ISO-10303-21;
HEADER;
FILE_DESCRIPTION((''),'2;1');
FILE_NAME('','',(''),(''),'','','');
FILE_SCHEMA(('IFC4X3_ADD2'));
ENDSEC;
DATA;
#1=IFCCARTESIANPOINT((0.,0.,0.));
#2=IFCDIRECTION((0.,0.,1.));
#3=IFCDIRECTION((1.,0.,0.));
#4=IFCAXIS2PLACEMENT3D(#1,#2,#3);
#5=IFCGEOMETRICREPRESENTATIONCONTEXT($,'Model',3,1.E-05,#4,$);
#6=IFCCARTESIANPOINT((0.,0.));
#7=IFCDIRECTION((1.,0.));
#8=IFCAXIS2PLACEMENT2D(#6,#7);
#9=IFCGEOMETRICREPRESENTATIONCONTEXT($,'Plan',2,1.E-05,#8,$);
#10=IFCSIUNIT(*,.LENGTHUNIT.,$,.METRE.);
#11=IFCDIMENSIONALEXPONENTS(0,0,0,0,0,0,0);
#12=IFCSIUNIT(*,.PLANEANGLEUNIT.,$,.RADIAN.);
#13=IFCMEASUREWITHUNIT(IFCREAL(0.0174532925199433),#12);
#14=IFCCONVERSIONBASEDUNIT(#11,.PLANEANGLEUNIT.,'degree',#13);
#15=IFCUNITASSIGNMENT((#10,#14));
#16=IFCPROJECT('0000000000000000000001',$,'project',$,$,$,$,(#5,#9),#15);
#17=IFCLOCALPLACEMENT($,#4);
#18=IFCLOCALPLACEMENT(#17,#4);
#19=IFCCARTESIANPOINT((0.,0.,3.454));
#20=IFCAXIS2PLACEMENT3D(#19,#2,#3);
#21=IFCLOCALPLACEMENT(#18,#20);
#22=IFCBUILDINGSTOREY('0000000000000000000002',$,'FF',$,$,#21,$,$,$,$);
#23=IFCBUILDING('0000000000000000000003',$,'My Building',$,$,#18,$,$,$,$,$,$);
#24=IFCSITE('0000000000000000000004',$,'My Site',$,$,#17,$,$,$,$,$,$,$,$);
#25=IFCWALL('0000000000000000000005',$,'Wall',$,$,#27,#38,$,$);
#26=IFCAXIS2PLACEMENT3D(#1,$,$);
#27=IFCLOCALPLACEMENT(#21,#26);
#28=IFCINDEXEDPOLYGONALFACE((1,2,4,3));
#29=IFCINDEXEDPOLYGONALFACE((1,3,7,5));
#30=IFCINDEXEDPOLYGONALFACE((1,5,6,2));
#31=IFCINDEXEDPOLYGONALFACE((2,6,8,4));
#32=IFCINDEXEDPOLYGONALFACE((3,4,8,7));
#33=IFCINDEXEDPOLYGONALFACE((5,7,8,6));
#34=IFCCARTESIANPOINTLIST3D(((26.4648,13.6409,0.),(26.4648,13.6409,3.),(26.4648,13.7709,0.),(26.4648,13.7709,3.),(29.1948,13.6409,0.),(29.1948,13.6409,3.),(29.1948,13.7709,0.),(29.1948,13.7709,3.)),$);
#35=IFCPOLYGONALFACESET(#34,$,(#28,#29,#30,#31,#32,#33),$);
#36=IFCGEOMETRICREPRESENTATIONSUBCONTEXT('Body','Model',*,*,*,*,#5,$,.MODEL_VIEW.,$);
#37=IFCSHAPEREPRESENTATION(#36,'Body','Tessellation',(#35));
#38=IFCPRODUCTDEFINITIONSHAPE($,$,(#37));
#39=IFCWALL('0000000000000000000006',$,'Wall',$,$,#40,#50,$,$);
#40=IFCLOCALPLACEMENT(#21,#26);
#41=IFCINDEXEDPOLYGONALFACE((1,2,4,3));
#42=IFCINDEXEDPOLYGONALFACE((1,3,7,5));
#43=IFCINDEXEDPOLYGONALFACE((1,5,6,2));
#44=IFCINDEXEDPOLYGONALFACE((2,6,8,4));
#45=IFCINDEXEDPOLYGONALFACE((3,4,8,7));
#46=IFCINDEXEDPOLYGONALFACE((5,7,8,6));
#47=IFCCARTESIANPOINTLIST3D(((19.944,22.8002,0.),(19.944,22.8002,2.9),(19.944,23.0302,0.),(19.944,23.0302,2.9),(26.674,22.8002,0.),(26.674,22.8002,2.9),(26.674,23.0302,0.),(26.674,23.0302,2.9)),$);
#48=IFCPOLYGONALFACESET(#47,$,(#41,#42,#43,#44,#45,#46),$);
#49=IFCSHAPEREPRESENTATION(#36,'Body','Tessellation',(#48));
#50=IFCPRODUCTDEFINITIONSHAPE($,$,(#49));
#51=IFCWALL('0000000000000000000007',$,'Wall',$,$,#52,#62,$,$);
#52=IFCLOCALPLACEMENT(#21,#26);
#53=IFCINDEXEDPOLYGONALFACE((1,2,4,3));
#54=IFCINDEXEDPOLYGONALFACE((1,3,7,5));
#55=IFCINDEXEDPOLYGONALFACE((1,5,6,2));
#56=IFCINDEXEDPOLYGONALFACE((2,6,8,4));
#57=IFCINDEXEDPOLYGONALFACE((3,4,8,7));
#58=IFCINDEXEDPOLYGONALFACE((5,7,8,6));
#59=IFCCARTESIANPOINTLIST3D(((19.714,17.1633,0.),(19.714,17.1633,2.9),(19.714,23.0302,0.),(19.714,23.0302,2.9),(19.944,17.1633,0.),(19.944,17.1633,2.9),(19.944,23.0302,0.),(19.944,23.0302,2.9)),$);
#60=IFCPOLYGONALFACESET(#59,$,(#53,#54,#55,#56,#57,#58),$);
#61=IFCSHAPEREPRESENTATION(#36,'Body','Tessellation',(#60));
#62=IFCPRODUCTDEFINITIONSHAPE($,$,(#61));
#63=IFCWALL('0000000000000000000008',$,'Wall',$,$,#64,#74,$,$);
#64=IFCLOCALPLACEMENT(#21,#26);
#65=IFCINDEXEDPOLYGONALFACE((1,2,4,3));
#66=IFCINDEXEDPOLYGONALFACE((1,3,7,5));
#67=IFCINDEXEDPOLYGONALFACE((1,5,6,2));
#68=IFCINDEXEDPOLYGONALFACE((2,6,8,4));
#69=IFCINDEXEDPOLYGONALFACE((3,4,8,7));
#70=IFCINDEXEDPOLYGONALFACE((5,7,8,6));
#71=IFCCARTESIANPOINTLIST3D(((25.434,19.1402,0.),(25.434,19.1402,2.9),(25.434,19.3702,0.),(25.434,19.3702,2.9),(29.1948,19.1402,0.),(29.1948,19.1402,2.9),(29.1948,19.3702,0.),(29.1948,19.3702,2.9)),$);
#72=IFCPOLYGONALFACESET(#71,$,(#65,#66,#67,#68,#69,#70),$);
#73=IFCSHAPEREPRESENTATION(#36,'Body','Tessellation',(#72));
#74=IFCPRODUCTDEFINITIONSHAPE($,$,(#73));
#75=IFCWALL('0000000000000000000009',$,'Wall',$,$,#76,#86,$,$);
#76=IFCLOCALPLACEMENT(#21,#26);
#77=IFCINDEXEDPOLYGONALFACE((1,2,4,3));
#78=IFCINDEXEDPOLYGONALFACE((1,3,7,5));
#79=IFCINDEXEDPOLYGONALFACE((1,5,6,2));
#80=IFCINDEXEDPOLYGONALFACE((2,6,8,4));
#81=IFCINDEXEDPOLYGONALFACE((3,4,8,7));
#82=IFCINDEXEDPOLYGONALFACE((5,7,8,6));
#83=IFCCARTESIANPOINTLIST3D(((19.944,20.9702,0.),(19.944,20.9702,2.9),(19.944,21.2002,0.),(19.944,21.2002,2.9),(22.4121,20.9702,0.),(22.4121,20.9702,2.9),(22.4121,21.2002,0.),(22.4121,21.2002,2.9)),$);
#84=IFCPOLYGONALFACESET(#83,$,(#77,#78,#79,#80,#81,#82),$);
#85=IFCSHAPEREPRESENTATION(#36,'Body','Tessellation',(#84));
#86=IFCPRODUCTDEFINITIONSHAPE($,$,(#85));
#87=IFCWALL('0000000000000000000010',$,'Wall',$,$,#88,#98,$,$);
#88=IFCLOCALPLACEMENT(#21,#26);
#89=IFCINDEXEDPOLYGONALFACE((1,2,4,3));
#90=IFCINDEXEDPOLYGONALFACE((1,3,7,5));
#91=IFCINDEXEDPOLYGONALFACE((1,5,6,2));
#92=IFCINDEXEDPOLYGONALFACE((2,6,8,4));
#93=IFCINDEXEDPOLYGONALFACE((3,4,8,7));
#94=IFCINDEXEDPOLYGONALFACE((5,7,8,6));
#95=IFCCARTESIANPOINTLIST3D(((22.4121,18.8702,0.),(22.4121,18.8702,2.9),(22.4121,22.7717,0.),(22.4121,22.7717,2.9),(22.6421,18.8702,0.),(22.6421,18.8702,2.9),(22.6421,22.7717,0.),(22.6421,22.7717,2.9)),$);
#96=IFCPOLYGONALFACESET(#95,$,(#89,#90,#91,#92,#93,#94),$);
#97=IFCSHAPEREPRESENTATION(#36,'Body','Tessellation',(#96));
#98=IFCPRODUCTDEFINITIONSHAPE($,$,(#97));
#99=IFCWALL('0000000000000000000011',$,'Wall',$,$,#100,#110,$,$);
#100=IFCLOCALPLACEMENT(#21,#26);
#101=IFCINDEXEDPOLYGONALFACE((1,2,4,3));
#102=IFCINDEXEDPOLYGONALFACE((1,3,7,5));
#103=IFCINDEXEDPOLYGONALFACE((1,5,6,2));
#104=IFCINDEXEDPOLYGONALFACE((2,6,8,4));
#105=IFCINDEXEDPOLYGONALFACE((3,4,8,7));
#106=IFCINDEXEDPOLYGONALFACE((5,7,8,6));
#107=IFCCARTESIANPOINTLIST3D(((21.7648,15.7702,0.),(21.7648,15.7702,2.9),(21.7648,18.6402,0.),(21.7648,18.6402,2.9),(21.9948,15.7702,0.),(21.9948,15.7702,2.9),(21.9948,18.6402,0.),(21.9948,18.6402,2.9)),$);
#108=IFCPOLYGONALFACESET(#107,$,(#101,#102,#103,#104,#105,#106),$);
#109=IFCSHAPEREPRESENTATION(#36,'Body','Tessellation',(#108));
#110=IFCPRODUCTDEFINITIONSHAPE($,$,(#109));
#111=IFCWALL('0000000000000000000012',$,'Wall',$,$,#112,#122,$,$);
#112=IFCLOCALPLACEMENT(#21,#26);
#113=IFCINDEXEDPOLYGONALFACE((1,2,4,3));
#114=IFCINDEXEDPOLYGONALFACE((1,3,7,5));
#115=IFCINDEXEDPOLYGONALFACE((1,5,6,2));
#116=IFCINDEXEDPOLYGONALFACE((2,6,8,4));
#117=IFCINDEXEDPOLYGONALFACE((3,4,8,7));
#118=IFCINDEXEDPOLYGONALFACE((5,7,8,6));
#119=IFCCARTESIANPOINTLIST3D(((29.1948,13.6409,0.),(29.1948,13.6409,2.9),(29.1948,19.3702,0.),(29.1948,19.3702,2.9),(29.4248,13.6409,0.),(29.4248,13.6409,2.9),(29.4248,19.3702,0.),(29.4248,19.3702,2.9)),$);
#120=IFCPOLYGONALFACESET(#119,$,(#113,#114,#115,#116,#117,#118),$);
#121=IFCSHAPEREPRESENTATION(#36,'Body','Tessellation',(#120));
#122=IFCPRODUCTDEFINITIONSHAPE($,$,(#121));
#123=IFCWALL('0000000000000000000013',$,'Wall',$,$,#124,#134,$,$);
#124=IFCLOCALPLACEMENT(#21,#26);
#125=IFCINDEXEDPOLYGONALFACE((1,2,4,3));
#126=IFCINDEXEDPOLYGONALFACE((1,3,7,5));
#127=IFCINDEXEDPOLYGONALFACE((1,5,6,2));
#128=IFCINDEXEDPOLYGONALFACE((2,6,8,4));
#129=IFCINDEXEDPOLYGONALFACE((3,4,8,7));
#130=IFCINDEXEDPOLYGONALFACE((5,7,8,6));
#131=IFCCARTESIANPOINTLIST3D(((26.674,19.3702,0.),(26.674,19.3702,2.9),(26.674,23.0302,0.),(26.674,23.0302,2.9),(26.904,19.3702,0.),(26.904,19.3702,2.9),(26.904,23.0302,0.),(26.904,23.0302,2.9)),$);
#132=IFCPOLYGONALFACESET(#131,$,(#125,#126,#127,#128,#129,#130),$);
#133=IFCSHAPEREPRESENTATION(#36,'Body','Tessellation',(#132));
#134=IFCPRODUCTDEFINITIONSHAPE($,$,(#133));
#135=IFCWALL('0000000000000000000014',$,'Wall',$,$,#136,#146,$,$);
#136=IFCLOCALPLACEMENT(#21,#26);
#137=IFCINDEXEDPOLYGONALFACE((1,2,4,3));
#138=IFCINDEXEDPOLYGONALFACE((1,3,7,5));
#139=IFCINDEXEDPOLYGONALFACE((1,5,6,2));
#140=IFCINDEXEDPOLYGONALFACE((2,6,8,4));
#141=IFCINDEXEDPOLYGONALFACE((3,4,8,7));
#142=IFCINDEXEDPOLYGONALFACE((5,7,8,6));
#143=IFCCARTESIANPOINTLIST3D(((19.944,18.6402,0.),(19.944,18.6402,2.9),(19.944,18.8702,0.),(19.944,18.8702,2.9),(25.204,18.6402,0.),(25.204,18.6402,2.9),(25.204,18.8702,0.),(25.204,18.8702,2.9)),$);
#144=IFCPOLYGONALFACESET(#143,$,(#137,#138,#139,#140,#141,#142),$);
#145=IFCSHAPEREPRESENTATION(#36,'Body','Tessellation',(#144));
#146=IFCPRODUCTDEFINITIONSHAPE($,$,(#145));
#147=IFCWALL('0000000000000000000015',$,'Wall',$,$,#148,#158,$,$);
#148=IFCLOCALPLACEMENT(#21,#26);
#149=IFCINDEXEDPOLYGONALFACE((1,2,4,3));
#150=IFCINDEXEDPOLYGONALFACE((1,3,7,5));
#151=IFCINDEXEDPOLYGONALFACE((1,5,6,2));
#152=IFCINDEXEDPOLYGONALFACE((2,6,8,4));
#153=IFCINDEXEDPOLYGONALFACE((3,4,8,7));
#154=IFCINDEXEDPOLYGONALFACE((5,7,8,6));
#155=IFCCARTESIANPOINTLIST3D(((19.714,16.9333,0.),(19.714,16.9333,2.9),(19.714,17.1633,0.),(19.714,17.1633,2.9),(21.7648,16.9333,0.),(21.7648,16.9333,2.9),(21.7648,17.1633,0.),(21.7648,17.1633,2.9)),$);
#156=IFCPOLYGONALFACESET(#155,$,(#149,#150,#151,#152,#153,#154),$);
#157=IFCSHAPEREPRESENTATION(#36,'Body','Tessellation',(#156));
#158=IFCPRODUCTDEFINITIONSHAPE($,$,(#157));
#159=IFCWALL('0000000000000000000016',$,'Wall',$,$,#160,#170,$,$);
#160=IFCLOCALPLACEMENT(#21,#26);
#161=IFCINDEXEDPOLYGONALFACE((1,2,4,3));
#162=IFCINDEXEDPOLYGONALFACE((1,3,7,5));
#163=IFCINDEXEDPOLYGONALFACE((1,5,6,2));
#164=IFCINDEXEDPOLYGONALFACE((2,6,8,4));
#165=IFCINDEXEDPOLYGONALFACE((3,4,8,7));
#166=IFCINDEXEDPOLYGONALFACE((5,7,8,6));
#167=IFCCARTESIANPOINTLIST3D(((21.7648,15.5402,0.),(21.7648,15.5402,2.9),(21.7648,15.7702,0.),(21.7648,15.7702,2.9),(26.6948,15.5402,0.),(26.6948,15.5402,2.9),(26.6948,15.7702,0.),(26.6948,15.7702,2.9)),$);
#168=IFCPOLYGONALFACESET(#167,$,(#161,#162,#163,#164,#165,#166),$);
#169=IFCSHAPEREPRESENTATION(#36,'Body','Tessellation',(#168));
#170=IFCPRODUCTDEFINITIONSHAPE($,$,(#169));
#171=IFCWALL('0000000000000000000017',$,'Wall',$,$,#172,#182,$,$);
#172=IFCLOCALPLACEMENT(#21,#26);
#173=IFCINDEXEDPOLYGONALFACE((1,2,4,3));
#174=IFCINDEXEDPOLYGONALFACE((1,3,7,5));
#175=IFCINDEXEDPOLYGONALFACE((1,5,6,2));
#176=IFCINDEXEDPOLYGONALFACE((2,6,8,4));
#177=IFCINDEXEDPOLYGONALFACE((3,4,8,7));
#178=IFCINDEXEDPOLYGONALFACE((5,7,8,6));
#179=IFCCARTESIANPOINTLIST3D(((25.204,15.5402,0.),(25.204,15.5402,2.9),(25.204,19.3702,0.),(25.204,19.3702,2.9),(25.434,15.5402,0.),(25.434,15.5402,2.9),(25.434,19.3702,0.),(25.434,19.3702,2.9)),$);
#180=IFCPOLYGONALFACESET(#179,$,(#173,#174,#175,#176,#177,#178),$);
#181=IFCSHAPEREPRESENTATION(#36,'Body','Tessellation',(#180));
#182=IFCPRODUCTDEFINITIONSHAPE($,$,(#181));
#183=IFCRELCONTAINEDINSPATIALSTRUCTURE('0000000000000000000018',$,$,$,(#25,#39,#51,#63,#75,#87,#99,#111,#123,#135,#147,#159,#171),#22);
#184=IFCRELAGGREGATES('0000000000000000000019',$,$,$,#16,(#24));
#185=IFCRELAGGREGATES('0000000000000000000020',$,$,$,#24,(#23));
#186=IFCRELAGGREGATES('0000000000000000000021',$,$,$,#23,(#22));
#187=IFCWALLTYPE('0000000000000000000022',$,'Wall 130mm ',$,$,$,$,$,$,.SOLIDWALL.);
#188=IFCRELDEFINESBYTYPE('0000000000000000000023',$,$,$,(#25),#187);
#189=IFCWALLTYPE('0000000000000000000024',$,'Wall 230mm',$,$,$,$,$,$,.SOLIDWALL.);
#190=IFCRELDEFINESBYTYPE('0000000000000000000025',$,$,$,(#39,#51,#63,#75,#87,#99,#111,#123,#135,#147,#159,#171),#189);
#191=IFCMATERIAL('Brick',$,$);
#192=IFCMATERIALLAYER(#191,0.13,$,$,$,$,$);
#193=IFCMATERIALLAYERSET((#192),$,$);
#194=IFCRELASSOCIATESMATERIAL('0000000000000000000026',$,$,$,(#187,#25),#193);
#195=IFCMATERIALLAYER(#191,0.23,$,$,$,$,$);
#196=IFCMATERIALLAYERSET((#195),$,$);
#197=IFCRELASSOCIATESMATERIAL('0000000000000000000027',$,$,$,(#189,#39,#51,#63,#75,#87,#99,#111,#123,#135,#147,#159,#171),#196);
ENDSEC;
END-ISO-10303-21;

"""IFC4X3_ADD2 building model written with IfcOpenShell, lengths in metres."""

from ifc_helpers import new_model, entity, si_unit, converted_unit, frame, origin_with_axes, origin_2d_with_axis, place, context, subcontext, project, spatial, indexed_curve, outline, extrude, material, layer, layer_set, layer_usage, type_object, element, save


model = new_model("IFC4X3_ADD2")

# Units and contexts
model_context = context("Model", 3, precision=1e-05, world=origin_with_axes())
plan_context = context("Plan", 2, precision=1e-05, world=origin_2d_with_axis())
body_context = subcontext(model_context, "Body", "Model", "MODEL_VIEW")
ifc_project = project(units=[si_unit("LENGTHUNIT", "METRE"), converted_unit("PLANEANGLEUNIT", "degree", entity("IfcReal", 0.0174532925199433), si_unit("PLANEANGLEUNIT", "RADIAN"), dimensions=[0, 0, 0, 0, 0, 0, 0])], contexts=[model_context, plan_context])

# Site, building, storey
site_placement = place(None, origin_with_axes())
site = spatial("IfcSite", under=ifc_project, at=site_placement, Name="My Site")
building_placement = place(site_placement, origin_with_axes())
building = spatial("IfcBuilding", under=site, at=building_placement, Name="My Building")
storey_placement = place(building_placement, frame((0.0, 0.0, 3.454), z_axis=(0.0, 0.0, 1.0), x_axis=(1.0, 0.0, 0.0)))
storey = spatial("IfcBuildingStorey", under=building, at=storey_placement, Name="FF")

# Walls
ifc_material = material(Name="Brick")
ifc_layer_1 = layer(ifc_material, 0.13)
ifc_layer_set_1 = layer_set([ifc_layer_1])
ifc_layer_usage_1 = layer_usage(ifc_layer_set_1, "AXIS2", "POSITIVE", 0.0)
wall_type_1 = type_object("IfcWallType", Name="Wall 130mm ", PredefinedType="SOLIDWALL", material=ifc_layer_set_1)
wall_1_placement = place(storey_placement, frame((29.1948, 13.7709, 0.0), z_axis=(0.0, 0.0, 1.0), x_axis=(-1.0, 0.0, 0.0)))
element("IfcWall", 1, at=wall_1_placement, inside=storey, type_object=wall_type_1, material=ifc_layer_usage_1, Name="Wall", context=body_context, shape_type="SweptSolid", body=[
    extrude(outline(indexed_curve([(0.0, 0.0), (0.0, 0.13), (2.73, 0.13), (2.73, 0.0), (0.0, 0.0)], self_intersect=False)), origin_with_axes(), (0.0, 0.0, 1.0), 3.0),
])
ifc_layer_2 = layer(ifc_material, 0.23)
ifc_layer_set_2 = layer_set([ifc_layer_2])
ifc_layer_usage_2 = layer_usage(ifc_layer_set_2, "AXIS2", "POSITIVE", 0.0)
wall_type_2 = type_object("IfcWallType", Name="Wall 230mm", PredefinedType="SOLIDWALL", material=ifc_layer_set_2)
wall_2_placement = place(storey_placement, frame((26.674, 23.0302, 0.0), z_axis=(0.0, 0.0, 1.0), x_axis=(-1.0, 0.0, 0.0)))
element("IfcWall", 2, at=wall_2_placement, inside=storey, type_object=wall_type_2, material=ifc_layer_usage_2, Name="Wall", context=body_context, shape_type="SweptSolid", body=[
    extrude(outline(indexed_curve([(0.0, 0.0), (0.0, 0.23), (6.73, 0.23), (6.73, 0.0), (0.0, 0.0)], self_intersect=False)), origin_with_axes(), (0.0, 0.0, 1.0), 2.9),
])
ifc_layer_usage_3 = layer_usage(ifc_layer_set_2, "AXIS2", "POSITIVE", 0.0)
wall_3_placement = place(storey_placement, frame((19.944, 17.1633, 0.0), z_axis=(0.0, 0.0, 1.0), x_axis=(0.000001, 1.0, 0.0)))
element("IfcWall", 3, at=wall_3_placement, inside=storey, type_object=wall_type_2, material=ifc_layer_usage_3, Name="Wall", context=body_context, shape_type="SweptSolid", body=[
    extrude(outline(indexed_curve([(0.0, 0.0), (0.0, 0.23), (5.8669, 0.23), (5.8669, 0.0), (0.0, 0.0)], self_intersect=False)), origin_with_axes(), (0.0, 0.0, 1.0), 2.9),
])
ifc_layer_usage_4 = layer_usage(ifc_layer_set_2, "AXIS2", "POSITIVE", 0.0)
wall_4_placement = place(storey_placement, frame((29.1948, 19.3702, 0.0), z_axis=(0.0, 0.0, 1.0), x_axis=(-1.0, 0.0, 0.0)))
element("IfcWall", 4, at=wall_4_placement, inside=storey, type_object=wall_type_2, material=ifc_layer_usage_4, Name="Wall", context=body_context, shape_type="SweptSolid", body=[
    extrude(outline(indexed_curve([(0.0, 0.0), (0.0, 0.23), (3.7608, 0.23), (3.7608, 0.0), (0.0, 0.0)], self_intersect=False)), origin_with_axes(), (0.0, 0.0, 1.0), 2.9),
])
ifc_layer_usage_5 = layer_usage(ifc_layer_set_2, "AXIS2", "POSITIVE", 0.0)
wall_5_placement = place(storey_placement, frame((22.4121, 21.2002, 0.0), z_axis=(0.0, 0.0, 1.0), x_axis=(-1.0, 0.0, 0.0)))
element("IfcWall", 5, at=wall_5_placement, inside=storey, type_object=wall_type_2, material=ifc_layer_usage_5, Name="Wall", context=body_context, shape_type="SweptSolid", body=[
    extrude(outline(indexed_curve([(0.0, 0.0), (0.0, 0.23), (2.4681, 0.23), (2.4681, 0.0), (0.0, 0.0)], self_intersect=False)), origin_with_axes(), (0.0, 0.0, 1.0), 2.9),
])
ifc_layer_usage_6 = layer_usage(ifc_layer_set_2, "AXIS2", "POSITIVE", 0.0)
wall_6_placement = place(storey_placement, frame((22.6421, 18.8702, 0.0), z_axis=(0.0, 0.0, 1.0), x_axis=(0.000001, 1.0, 0.0)))
element("IfcWall", 6, at=wall_6_placement, inside=storey, type_object=wall_type_2, material=ifc_layer_usage_6, Name="Wall", context=body_context, shape_type="SweptSolid", body=[
    extrude(outline(indexed_curve([(0.0, 0.0), (0.0, 0.23), (3.9015, 0.23), (3.9015, 0.0), (0.0, 0.0)], self_intersect=False)), origin_with_axes(), (0.0, 0.0, 1.0), 2.9),
])
ifc_layer_usage_7 = layer_usage(ifc_layer_set_2, "AXIS2", "POSITIVE", 0.0)
wall_7_placement = place(storey_placement, frame((21.9948, 15.7702, 0.0), z_axis=(0.0, 0.0, 1.0), x_axis=(0.000001, 1.0, 0.0)))
element("IfcWall", 7, at=wall_7_placement, inside=storey, type_object=wall_type_2, material=ifc_layer_usage_7, Name="Wall", context=body_context, shape_type="SweptSolid", body=[
    extrude(outline(indexed_curve([(0.0, 0.0), (0.0, 0.23), (2.87, 0.23), (2.87, 0.0), (0.0, 0.0)], self_intersect=False)), origin_with_axes(), (0.0, 0.0, 1.0), 2.9),
])
ifc_layer_usage_8 = layer_usage(ifc_layer_set_2, "AXIS2", "POSITIVE", 0.0)
wall_8_placement = place(storey_placement, frame((29.4248, 13.6409, 0.0), z_axis=(0.0, 0.0, 1.0), x_axis=(0.000001, 1.0, 0.0)))
element("IfcWall", 8, at=wall_8_placement, inside=storey, type_object=wall_type_2, material=ifc_layer_usage_8, Name="Wall", context=body_context, shape_type="SweptSolid", body=[
    extrude(outline(indexed_curve([(0.0, 0.0), (0.0, 0.23), (5.7293, 0.23), (5.7293, 0.0), (0.0, 0.0)], self_intersect=False)), origin_with_axes(), (0.0, 0.0, 1.0), 2.9),
])
ifc_layer_usage_9 = layer_usage(ifc_layer_set_2, "AXIS2", "POSITIVE", 0.0)
wall_9_placement = place(storey_placement, frame((26.904, 19.3702, 0.0), z_axis=(0.0, 0.0, 1.0), x_axis=(0.000001, 1.0, 0.0)))
element("IfcWall", 9, at=wall_9_placement, inside=storey, type_object=wall_type_2, material=ifc_layer_usage_9, Name="Wall", context=body_context, shape_type="SweptSolid", body=[
    extrude(outline(indexed_curve([(0.0, 0.0), (0.0, 0.23), (3.66, 0.23), (3.66, 0.0), (0.0, 0.0)], self_intersect=False)), origin_with_axes(), (0.0, 0.0, 1.0), 2.9),
])
ifc_layer_usage_10 = layer_usage(ifc_layer_set_2, "AXIS2", "POSITIVE", 0.0)
wall_10_placement = place(storey_placement, frame((25.204, 18.8702, 0.0), z_axis=(0.0, 0.0, 1.0), x_axis=(-1.0, 0.0, 0.0)))
element("IfcWall", 10, at=wall_10_placement, inside=storey, type_object=wall_type_2, material=ifc_layer_usage_10, Name="Wall", context=body_context, shape_type="SweptSolid", body=[
    extrude(outline(indexed_curve([(0.0, 0.0), (0.0, 0.23), (5.26, 0.23), (5.26, 0.0), (0.0, 0.0)], self_intersect=False)), origin_with_axes(), (0.0, 0.0, 1.0), 2.9),
])
ifc_layer_usage_11 = layer_usage(ifc_layer_set_2, "AXIS2", "POSITIVE", 0.0)
wall_11_placement = place(storey_placement, frame((21.7648, 17.1633, 0.0), z_axis=(0.0, 0.0, 1.0), x_axis=(-1.0, 0.0, 0.0)))
element("IfcWall", 11, at=wall_11_placement, inside=storey, type_object=wall_type_2, material=ifc_layer_usage_11, Name="Wall", context=body_context, shape_type="SweptSolid", body=[
    extrude(outline(indexed_curve([(0.0, 0.0), (0.0, 0.23), (2.0508, 0.23), (2.0508, 0.0), (0.0, 0.0)], self_intersect=False)), origin_with_axes(), (0.0, 0.0, 1.0), 2.9),
])
ifc_layer_usage_12 = layer_usage(ifc_layer_set_2, "AXIS2", "POSITIVE", 0.0)
wall_12_placement = place(storey_placement, frame((26.6948, 15.7702, 0.0), z_axis=(0.0, 0.0, 1.0), x_axis=(-1.0, 0.0, 0.0)))
element("IfcWall", 12, at=wall_12_placement, inside=storey, type_object=wall_type_2, material=ifc_layer_usage_12, Name="Wall", context=body_context, shape_type="SweptSolid", body=[
    extrude(outline(indexed_curve([(0.0, 0.0), (0.0, 0.23), (4.93, 0.23), (4.93, 0.0), (0.0, 0.0)], self_intersect=False)), origin_with_axes(), (0.0, 0.0, 1.0), 2.9),
])
ifc_layer_usage_13 = layer_usage(ifc_layer_set_2, "AXIS2", "POSITIVE", 0.0)
wall_13_placement = place(storey_placement, frame((25.434, 15.5402, 0.0), z_axis=(0.0, 0.0, 1.0), x_axis=(0.000001, 1.0, 0.0)))
element("IfcWall", 13, at=wall_13_placement, inside=storey, type_object=wall_type_2, material=ifc_layer_usage_13, Name="Wall", context=body_context, shape_type="SweptSolid", body=[
    extrude(outline(indexed_curve([(0.0, 0.0), (0.0, 0.23), (3.83, 0.23), (3.83, 0.0), (0.0, 0.0)], self_intersect=False)), origin_with_axes(), (0.0, 0.0, 1.0), 2.9),
])

save(model, "model.ifc")
